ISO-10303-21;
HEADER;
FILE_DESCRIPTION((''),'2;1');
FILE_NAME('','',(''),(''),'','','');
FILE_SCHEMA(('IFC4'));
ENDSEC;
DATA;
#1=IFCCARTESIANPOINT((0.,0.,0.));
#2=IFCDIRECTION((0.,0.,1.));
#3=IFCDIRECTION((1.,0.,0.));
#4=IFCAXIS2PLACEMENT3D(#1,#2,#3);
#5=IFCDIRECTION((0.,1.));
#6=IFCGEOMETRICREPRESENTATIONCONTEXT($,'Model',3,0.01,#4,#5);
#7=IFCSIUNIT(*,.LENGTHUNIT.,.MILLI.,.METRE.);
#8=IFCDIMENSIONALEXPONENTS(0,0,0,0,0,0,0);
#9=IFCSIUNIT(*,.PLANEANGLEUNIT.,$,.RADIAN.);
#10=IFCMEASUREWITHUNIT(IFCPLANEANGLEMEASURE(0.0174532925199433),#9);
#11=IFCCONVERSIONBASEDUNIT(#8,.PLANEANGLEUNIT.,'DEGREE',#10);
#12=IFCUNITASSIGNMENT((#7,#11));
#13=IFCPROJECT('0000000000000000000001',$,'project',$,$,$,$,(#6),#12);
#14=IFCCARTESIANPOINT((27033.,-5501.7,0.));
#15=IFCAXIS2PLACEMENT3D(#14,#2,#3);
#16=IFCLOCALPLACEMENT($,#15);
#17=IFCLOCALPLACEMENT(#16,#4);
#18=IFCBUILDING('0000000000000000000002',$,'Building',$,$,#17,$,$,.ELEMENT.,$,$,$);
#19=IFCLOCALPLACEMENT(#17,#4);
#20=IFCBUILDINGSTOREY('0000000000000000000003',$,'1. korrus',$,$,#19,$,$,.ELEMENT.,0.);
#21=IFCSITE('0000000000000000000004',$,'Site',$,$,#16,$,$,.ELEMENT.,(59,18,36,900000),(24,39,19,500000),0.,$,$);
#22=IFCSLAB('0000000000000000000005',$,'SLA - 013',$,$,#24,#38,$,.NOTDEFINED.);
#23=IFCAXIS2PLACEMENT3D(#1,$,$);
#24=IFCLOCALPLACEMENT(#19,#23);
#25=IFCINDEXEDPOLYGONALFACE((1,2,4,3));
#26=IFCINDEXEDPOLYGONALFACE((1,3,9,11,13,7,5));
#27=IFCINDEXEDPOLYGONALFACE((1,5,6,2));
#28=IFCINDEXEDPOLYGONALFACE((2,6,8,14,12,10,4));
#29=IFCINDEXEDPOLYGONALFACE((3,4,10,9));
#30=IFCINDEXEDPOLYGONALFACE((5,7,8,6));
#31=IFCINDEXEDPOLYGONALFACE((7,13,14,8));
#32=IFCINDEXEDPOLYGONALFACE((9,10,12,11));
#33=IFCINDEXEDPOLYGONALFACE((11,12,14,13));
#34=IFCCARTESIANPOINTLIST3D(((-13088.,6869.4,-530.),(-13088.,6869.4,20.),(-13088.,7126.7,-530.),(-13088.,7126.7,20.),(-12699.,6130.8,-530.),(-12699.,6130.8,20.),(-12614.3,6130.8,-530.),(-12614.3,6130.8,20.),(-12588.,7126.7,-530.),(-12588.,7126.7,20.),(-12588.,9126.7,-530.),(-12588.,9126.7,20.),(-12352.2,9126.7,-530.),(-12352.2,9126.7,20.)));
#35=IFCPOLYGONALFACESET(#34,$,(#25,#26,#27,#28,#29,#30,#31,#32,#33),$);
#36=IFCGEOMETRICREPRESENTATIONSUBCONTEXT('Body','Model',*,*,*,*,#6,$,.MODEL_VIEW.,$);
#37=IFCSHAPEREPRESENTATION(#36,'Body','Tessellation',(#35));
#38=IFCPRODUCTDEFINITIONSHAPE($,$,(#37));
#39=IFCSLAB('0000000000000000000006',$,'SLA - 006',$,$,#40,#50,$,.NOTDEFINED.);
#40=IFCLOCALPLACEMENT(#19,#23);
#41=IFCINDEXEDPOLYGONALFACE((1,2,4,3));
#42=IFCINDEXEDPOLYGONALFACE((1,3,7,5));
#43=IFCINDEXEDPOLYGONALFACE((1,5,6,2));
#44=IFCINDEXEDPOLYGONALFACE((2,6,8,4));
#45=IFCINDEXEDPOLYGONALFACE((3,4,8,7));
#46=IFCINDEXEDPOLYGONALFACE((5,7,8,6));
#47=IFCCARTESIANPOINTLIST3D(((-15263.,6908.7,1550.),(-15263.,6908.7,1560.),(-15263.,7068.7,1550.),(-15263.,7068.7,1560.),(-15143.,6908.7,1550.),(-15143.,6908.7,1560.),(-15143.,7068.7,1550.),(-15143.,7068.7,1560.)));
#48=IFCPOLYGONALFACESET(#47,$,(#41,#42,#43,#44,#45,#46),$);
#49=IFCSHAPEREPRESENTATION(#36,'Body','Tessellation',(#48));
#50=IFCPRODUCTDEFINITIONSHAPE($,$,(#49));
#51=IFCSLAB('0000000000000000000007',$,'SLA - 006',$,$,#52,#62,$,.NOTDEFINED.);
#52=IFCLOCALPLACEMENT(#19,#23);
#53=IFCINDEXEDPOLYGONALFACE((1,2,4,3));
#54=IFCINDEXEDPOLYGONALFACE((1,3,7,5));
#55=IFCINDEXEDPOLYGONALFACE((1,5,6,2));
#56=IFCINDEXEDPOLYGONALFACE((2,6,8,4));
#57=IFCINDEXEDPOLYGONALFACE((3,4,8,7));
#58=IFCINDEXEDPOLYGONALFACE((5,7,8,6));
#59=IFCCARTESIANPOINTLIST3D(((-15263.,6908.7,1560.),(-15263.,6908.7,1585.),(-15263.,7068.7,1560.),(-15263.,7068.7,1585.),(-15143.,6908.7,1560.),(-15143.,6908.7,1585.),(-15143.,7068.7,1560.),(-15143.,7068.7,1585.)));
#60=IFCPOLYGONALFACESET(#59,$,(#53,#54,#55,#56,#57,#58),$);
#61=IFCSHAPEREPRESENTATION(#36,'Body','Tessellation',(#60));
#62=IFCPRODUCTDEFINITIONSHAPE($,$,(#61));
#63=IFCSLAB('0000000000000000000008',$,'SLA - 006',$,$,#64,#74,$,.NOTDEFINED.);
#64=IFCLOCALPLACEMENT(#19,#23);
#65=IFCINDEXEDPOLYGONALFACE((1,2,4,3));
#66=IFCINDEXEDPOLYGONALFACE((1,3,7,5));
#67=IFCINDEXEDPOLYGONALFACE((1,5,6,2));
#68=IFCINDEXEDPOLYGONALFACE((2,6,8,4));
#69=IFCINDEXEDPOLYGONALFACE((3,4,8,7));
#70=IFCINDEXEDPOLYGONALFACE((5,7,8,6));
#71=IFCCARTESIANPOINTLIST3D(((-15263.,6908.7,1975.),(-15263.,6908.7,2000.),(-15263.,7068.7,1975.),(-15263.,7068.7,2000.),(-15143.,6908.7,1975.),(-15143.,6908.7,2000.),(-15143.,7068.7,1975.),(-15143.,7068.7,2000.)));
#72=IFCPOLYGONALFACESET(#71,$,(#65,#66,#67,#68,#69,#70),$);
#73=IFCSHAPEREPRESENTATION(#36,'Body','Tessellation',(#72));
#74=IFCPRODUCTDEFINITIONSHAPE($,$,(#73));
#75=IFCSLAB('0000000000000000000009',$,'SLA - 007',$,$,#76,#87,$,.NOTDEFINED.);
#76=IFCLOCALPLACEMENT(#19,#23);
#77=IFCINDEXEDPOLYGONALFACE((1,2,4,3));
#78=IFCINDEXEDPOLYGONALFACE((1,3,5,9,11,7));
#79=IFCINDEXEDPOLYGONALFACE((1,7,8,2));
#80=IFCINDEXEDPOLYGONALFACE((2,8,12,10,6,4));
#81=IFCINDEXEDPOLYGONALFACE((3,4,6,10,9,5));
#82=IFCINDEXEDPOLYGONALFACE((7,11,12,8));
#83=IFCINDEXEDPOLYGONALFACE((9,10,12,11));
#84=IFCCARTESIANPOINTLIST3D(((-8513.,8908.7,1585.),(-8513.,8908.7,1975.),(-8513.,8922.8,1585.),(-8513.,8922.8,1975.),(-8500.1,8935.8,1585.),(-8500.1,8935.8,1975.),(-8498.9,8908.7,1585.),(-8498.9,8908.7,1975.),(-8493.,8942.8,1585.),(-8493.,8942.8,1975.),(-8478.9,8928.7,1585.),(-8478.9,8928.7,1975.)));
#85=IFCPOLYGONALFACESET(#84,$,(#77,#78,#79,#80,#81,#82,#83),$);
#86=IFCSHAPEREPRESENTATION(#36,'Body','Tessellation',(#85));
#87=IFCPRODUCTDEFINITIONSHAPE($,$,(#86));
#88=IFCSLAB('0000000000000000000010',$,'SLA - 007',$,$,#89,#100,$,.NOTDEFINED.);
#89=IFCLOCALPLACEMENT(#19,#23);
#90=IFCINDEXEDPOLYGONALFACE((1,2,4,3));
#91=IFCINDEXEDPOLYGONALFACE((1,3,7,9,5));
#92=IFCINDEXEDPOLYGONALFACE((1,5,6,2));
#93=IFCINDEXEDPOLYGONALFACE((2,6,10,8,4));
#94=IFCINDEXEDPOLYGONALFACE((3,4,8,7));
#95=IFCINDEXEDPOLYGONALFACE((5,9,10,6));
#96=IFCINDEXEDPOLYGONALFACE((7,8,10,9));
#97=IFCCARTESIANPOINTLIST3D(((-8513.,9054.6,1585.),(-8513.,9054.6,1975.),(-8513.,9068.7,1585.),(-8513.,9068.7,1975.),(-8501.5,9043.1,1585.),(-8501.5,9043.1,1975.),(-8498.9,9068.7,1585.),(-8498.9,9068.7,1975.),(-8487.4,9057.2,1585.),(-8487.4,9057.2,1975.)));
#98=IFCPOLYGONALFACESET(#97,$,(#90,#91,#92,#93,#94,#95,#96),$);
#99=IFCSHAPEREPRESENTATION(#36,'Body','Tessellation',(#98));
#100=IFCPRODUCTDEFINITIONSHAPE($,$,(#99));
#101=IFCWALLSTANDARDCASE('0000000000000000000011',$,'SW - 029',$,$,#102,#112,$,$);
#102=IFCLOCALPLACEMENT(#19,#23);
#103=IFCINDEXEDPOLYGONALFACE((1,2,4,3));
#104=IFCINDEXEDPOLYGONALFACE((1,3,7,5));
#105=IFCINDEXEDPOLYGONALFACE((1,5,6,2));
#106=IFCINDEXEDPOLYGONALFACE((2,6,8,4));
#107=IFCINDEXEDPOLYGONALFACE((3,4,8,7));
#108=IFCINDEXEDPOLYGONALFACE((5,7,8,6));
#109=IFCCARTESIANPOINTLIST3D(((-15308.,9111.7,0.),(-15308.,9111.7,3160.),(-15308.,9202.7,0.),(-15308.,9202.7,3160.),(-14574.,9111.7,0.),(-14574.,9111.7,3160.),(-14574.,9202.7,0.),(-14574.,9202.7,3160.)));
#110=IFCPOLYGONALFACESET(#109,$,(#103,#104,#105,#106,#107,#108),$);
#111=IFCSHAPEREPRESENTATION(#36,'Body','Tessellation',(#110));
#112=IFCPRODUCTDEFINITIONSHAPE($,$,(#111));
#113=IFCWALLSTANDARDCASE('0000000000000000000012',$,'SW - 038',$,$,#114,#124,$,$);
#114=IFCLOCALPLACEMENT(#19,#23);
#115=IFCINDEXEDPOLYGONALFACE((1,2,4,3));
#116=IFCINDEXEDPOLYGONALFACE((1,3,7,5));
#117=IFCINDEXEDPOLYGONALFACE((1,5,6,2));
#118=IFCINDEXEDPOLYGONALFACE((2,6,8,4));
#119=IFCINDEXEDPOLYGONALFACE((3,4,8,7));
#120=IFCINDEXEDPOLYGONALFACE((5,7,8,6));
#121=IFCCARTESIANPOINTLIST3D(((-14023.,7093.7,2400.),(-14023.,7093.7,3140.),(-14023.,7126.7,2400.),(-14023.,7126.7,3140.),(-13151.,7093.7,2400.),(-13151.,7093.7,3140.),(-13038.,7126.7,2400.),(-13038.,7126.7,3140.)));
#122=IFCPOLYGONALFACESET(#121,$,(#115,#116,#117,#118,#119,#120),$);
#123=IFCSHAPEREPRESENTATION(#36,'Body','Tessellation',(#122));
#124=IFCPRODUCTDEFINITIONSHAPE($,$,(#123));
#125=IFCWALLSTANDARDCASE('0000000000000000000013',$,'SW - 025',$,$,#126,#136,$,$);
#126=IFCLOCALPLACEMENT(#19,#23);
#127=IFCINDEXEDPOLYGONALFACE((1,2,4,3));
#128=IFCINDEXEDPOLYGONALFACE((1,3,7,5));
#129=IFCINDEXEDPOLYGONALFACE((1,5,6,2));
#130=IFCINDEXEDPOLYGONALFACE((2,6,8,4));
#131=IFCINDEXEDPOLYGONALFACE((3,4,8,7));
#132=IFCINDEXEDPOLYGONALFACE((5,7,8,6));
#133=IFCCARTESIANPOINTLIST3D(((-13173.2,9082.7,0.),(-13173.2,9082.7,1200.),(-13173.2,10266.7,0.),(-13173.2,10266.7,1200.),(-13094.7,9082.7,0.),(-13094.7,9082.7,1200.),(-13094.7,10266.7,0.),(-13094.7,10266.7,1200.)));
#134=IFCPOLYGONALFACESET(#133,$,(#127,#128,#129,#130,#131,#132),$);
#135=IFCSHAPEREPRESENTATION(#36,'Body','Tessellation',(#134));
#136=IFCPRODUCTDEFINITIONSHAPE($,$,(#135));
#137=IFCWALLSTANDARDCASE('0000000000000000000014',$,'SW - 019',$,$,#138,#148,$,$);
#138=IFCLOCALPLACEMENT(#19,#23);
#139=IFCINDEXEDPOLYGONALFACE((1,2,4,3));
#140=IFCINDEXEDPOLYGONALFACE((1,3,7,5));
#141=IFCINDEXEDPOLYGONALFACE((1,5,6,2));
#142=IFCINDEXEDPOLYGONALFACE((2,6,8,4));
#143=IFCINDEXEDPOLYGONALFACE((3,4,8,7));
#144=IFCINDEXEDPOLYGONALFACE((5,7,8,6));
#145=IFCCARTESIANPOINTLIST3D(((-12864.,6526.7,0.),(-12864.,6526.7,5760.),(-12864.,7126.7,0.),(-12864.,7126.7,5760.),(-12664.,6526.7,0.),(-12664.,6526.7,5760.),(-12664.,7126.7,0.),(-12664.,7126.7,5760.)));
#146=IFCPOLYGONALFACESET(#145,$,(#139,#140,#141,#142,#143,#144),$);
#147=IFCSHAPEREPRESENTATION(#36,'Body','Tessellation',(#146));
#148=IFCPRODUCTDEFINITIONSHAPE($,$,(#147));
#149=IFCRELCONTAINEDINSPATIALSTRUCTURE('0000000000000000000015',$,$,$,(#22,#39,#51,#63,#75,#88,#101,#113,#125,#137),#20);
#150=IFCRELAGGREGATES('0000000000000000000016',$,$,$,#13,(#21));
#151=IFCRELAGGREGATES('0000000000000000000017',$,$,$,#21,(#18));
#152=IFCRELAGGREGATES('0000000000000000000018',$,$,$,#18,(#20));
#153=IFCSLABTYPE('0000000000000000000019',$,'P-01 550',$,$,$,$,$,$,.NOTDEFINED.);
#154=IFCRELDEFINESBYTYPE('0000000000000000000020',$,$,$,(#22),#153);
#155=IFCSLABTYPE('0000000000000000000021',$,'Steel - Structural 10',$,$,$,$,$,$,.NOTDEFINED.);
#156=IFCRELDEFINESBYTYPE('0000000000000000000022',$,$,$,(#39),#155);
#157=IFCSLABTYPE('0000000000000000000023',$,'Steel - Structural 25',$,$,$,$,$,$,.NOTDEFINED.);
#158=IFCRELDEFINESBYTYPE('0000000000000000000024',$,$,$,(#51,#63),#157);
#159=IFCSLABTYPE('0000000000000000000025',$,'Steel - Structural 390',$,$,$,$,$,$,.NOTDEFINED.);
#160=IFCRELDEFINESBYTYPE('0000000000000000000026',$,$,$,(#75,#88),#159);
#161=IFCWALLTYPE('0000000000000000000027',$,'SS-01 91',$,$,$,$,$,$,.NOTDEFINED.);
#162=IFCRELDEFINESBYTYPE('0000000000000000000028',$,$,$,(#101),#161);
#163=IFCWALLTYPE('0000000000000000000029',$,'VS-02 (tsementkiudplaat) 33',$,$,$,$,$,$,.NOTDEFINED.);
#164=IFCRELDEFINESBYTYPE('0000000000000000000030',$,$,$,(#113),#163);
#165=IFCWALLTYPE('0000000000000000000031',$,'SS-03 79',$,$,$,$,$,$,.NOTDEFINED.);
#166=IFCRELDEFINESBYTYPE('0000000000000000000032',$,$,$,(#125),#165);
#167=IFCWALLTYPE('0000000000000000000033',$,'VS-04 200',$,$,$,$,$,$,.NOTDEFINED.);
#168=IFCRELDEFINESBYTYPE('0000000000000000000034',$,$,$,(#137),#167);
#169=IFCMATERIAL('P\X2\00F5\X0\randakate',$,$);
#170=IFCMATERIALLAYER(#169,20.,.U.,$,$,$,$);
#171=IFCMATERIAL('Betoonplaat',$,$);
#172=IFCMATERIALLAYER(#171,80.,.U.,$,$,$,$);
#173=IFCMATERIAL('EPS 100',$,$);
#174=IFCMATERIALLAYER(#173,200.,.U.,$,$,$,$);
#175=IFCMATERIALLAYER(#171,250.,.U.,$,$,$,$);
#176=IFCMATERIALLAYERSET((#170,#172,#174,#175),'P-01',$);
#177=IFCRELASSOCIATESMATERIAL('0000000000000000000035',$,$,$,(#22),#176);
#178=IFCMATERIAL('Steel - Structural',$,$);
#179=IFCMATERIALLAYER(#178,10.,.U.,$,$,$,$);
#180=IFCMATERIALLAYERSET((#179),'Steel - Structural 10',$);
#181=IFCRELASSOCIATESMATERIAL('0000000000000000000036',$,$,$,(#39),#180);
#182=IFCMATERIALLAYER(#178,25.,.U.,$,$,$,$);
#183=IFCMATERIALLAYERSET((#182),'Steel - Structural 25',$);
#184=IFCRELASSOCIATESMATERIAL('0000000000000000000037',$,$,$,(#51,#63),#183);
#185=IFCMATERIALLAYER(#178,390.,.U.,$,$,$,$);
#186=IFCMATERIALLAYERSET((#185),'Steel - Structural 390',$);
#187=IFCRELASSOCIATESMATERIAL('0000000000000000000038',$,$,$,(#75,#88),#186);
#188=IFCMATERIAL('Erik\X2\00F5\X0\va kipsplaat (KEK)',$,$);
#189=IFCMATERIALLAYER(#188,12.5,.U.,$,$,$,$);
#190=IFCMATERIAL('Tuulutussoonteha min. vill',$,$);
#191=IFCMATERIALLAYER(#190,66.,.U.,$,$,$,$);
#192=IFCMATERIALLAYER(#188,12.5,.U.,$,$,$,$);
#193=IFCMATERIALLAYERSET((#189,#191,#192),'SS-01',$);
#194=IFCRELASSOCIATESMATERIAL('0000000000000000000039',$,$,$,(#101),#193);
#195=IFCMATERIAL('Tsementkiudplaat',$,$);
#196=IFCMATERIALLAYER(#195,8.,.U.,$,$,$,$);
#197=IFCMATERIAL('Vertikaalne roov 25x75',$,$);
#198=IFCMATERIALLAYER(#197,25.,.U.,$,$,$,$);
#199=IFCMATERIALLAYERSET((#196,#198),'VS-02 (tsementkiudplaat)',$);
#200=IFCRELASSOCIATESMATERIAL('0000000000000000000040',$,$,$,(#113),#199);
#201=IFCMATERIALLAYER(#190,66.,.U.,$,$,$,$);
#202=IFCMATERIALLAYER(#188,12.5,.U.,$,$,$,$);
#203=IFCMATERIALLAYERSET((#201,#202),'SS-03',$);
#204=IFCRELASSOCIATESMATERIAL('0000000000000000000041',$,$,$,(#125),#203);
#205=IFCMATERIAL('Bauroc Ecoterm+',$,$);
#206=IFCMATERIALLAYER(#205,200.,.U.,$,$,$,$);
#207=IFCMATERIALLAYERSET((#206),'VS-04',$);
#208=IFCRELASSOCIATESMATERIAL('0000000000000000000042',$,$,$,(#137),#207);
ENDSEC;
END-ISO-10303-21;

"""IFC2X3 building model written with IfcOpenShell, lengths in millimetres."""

from ifc_helpers import new_model, entity, si_unit, converted_unit, direction, frame, origin_with_axes, origin_2d_with_axis, place, context, subcontext, project, spatial, polyline, rectangle, outline, extrude, material, layer, layer_set, layer_usage, type_object, element, save


model = new_model("IFC2X3")

# Units and contexts
model_context = context("Model", 3, precision=0.01, world=origin_with_axes(), true_north=direction((0.0, 1.0)))
body_context = subcontext(model_context, "Body", "Model", "MODEL_VIEW")
ifc_project = project(units=[si_unit("LENGTHUNIT", "METRE", prefix="MILLI"), converted_unit("PLANEANGLEUNIT", "DEGREE", entity("IfcPlaneAngleMeasure", 0.0174532925199433), si_unit("PLANEANGLEUNIT", "RADIAN"), dimensions=[0, 0, 0, 0, 0, 0, 0])], contexts=[model_context])

# Site, building, storey
site_placement = place(None, frame((27033.0, -5501.7, 0.0), z_axis=(0.0, 0.0, 1.0), x_axis=(1.0, 0.0, 0.0)))
site = spatial("IfcSite", under=ifc_project, at=site_placement, Name="Site", CompositionType="ELEMENT", RefLatitude=(59, 18, 36, 900000), RefLongitude=(24, 39, 19, 500000), RefElevation=0.0)
building_placement = place(site_placement, origin_with_axes())
building = spatial("IfcBuilding", under=site, at=building_placement, Name="Building", CompositionType="ELEMENT")
storey_placement = place(building_placement, origin_with_axes())
storey = spatial("IfcBuildingStorey", under=building, at=storey_placement, Name="1. korrus", CompositionType="ELEMENT", Elevation=0.0)

# Slabs
ifc_material_1 = material(Name="Põrandakate")
ifc_layer_1 = layer(ifc_material_1, 20.0, ventilated="UNKNOWN")
ifc_material_2 = material(Name="Betoonplaat")
ifc_layer_2 = layer(ifc_material_2, 80.0, ventilated="UNKNOWN")
ifc_material_3 = material(Name="EPS 100")
ifc_layer_3 = layer(ifc_material_3, 200.0, ventilated="UNKNOWN")
ifc_layer_4 = layer(ifc_material_2, 250.0, ventilated="UNKNOWN")
ifc_layer_set_1 = layer_set([ifc_layer_1, ifc_layer_2, ifc_layer_3, ifc_layer_4], Name="P-01")
ifc_layer_usage_1 = layer_usage(ifc_layer_set_1, "AXIS3", "NEGATIVE", 550.0)
slab_type_1 = type_object("IfcSlabType", Name="P-01 550", PredefinedType="NOTDEFINED")
slab_1_placement = place(storey_placement, frame((-12588.0, 7126.7, 0.0), z_axis=(0.0, 0.0, 1.0), x_axis=(1.0, 0.0, 0.0)))
element("IfcSlab", 1, at=slab_1_placement, inside=storey, type_object=slab_type_1, material=ifc_layer_usage_1, Name="SLA - 013", PredefinedType="NOTDEFINED", context=body_context, shape_type="SweptSolid", body=[
    extrude(outline(polyline([(0.0, 0.0), (-500.0, 0.0), (-500.0, -257.3), (-111.0, -995.9), (-26.3, -995.9), (235.8, 2000.0), (0.0, 2000.0), (0.0, 0.0)])), frame((0.0, 0.0, -530.0), z_axis=(0.0, 0.0, 1.0), x_axis=(1.0, 0.0, 0.0)), (0.0, 0.0, 1.0), 550.0),
])
ifc_material_4 = material(Name="Steel - Structural")
ifc_layer_5 = layer(ifc_material_4, 10.0, ventilated="UNKNOWN")
ifc_layer_set_2 = layer_set([ifc_layer_5], Name="Steel - Structural 10")
ifc_layer_usage_2 = layer_usage(ifc_layer_set_2, "AXIS3", "NEGATIVE", 10.0)
slab_type_2 = type_object("IfcSlabType", Name="Steel - Structural 10", PredefinedType="NOTDEFINED")
slab_2_placement = place(storey_placement, frame((-15143.0, 7068.7, 1550.0), z_axis=(0.0, 0.0, 1.0), x_axis=(1.0, 0.0, 0.0)))
element("IfcSlab", 2, at=slab_2_placement, inside=storey, type_object=slab_type_2, material=ifc_layer_usage_2, Name="SLA - 006", PredefinedType="NOTDEFINED", context=body_context, shape_type="SweptSolid", body=[
    extrude(outline(polyline([(0.0, 0.0), (-120.0, 0.0), (-120.0, -160.0), (0.0, -160.0), (0.0, 0.0)])), origin_with_axes(), (0.0, 0.0, 1.0), 10.0),
])
ifc_layer_6 = layer(ifc_material_4, 25.0, ventilated="UNKNOWN")
ifc_layer_set_3 = layer_set([ifc_layer_6], Name="Steel - Structural 25")
ifc_layer_usage_3 = layer_usage(ifc_layer_set_3, "AXIS3", "NEGATIVE", 25.0)
slab_type_3 = type_object("IfcSlabType", Name="Steel - Structural 25", PredefinedType="NOTDEFINED")
slab_3_placement = place(storey_placement, frame((-15143.0, 7068.7, 1560.0), z_axis=(0.0, 0.0, 1.0), x_axis=(1.0, 0.0, 0.0)))
element("IfcSlab", 3, at=slab_3_placement, inside=storey, type_object=slab_type_3, material=ifc_layer_usage_3, Name="SLA - 006", PredefinedType="NOTDEFINED", context=body_context, shape_type="SweptSolid", body=[
    extrude(outline(polyline([(0.0, 0.0), (-120.0, 0.0), (-120.0, -160.0), (0.0, -160.0), (0.0, 0.0)])), origin_with_axes(), (0.0, 0.0, 1.0), 25.0),
])
ifc_layer_usage_4 = layer_usage(ifc_layer_set_3, "AXIS3", "NEGATIVE", 25.0)
slab_4_placement = place(storey_placement, frame((-15143.0, 7068.7, 2000.0), z_axis=(0.0, 0.0, 1.0), x_axis=(1.0, 0.0, 0.0)))
element("IfcSlab", 4, at=slab_4_placement, inside=storey, type_object=slab_type_3, material=ifc_layer_usage_4, Name="SLA - 006", PredefinedType="NOTDEFINED", context=body_context, shape_type="SweptSolid", body=[
    extrude(outline(polyline([(0.0, 0.0), (-120.0, 0.0), (-120.0, -160.0), (0.0, -160.0), (0.0, 0.0)])), frame((0.0, 0.0, -25.0), z_axis=(0.0, 0.0, 1.0), x_axis=(1.0, 0.0, 0.0)), (0.0, 0.0, 1.0), 25.0),
])
ifc_layer_7 = layer(ifc_material_4, 390.0, ventilated="UNKNOWN")
ifc_layer_set_4 = layer_set([ifc_layer_7], Name="Steel - Structural 390")
ifc_layer_usage_5 = layer_usage(ifc_layer_set_4, "AXIS3", "NEGATIVE", 390.0)
slab_type_4 = type_object("IfcSlabType", Name="Steel - Structural 390", PredefinedType="NOTDEFINED")
slab_5_placement = place(storey_placement, frame((-8500.1, 8935.8, 1585.0), z_axis=(0.0, 0.0, 1.0), x_axis=(1.0, 0.0, 0.0)))
element("IfcSlab", 5, at=slab_5_placement, inside=storey, type_object=slab_type_4, material=ifc_layer_usage_5, Name="SLA - 007", PredefinedType="NOTDEFINED", context=body_context, shape_type="SweptSolid", body=[
    extrude(outline(polyline([(0.0, 0.0), (-12.9, -12.9), (-12.9, -27.1), (1.2, -27.1), (21.2, -7.1), (7.1, 7.1), (0.0, 0.0)])), origin_with_axes(), (0.0, 0.0, 1.0), 390.0),
])
ifc_layer_usage_6 = layer_usage(ifc_layer_set_4, "AXIS3", "NEGATIVE", 390.0)
slab_6_placement = place(storey_placement, frame((-8501.5, 9043.1, 1585.0), z_axis=(0.0, 0.0, 1.0), x_axis=(1.0, 0.0, 0.0)))
element("IfcSlab", 6, at=slab_6_placement, inside=storey, type_object=slab_type_4, material=ifc_layer_usage_6, Name="SLA - 007", PredefinedType="NOTDEFINED", context=body_context, shape_type="SweptSolid", body=[
    extrude(outline(polyline([(0.0, 0.0), (14.1, 14.1), (2.7, 25.6), (-11.5, 25.6), (-11.5, 11.5), (0.0, 0.0)])), origin_with_axes(), (0.0, 0.0, 1.0), 390.0),
])

# Shared definitions
ifc_material_5 = material(Name="Bauroc Ecoterm+")

# Shared definitions
ifc_material_6 = material(Name="Erikõva kipsplaat (KEK)")
ifc_layer_8 = layer(ifc_material_6, 12.5, ventilated="UNKNOWN")
ifc_material_7 = material(Name="Tuulutussoonteha min. vill")
ifc_layer_9 = layer(ifc_material_7, 66.0, ventilated="UNKNOWN")
ifc_layer_10 = layer(ifc_material_6, 12.5, ventilated="UNKNOWN")
ifc_layer_set_5 = layer_set([ifc_layer_8, ifc_layer_9, ifc_layer_10], Name="SS-01")
wall_type_1 = type_object("IfcWallType", Name="SS-01 91", PredefinedType="NOTDEFINED")

# Wall
ifc_layer_usage_7 = layer_usage(ifc_layer_set_5, "AXIS2", "POSITIVE", -91.0)
wall_1_placement = place(storey_placement, frame((-14574.0, 9111.7, 0.0), z_axis=(0.0, 0.0, 1.0), x_axis=(-1.0, 0.0, 0.0)))
element("IfcWallStandardCase", 7, at=wall_1_placement, inside=storey, type_object=wall_type_1, material=ifc_layer_usage_7, Name="SW - 029", context=body_context, shape_type="SweptSolid", body=[
    extrude(outline(polyline([(0.0, -91.0), (734.0, -91.0), (734.0, 0.0), (0.0, 0.0), (0.0, -91.0)])), origin_with_axes(), (0.0, 0.0, 1.0), 3160.0),
])

# Wall, opening
ifc_material_8 = material(Name="Tsementkiudplaat")
ifc_layer_11 = layer(ifc_material_8, 8.0, ventilated="UNKNOWN")
ifc_material_9 = material(Name="Vertikaalne roov 25x75")
ifc_layer_12 = layer(ifc_material_9, 25.0, ventilated="UNKNOWN")
ifc_layer_set_6 = layer_set([ifc_layer_11, ifc_layer_12], Name="VS-02 (tsementkiudplaat)")
ifc_layer_usage_8 = layer_usage(ifc_layer_set_6, "AXIS2", "POSITIVE", -33.0)
wall_type_2 = type_object("IfcWallType", Name="VS-02 (tsementkiudplaat) 33", PredefinedType="NOTDEFINED")
wall_2_placement = place(storey_placement, frame((-14023.0, 7126.7, 2400.0), z_axis=(0.0, 0.0, 1.0), x_axis=(1.0, 0.0, 0.0)))
wall_2 = element("IfcWallStandardCase", 8, at=wall_2_placement, inside=storey, type_object=wall_type_2, material=ifc_layer_usage_8, Name="SW - 038", context=body_context, shape_type="SweptSolid", body=[
    extrude(outline(polyline([(0.0, -33.0), (872.0, -33.0), (985.0, 0.0), (0.0, 0.0), (0.0, -33.0)])), origin_with_axes(), (0.0, 0.0, 1.0), 740.0),
])
opening_1_placement = place(wall_2_placement, frame((431.0, 0.0, -2400.0), z_axis=(0.0, 0.0, 1.0), x_axis=(1.0, 0.0, 0.0)))
element("IfcOpeningElement", 9, at=opening_1_placement, cuts=wall_2, context=body_context, shape_type="SweptSolid", body=[
    extrude(rectangle(XDim=882.0, YDim=2400.0, at=origin_2d_with_axis()), frame((0.0, 33.0, 1200.0), z_axis=(0.0, 1.0, 0.0), x_axis=(-1.0, 0.0, 0.0)), (0.0, 0.0, -1.0), 99.0),
])

# Walls
ifc_layer_13 = layer(ifc_material_7, 66.0, ventilated="UNKNOWN")
ifc_layer_14 = layer(ifc_material_6, 12.5, ventilated="UNKNOWN")
ifc_layer_set_7 = layer_set([ifc_layer_13, ifc_layer_14], Name="SS-03")
ifc_layer_usage_9 = layer_usage(ifc_layer_set_7, "AXIS2", "POSITIVE", -78.5)
wall_type_3 = type_object("IfcWallType", Name="SS-03 79", PredefinedType="NOTDEFINED")
wall_3_placement = place(storey_placement, frame((-13173.2, 9082.7, 0.0), z_axis=(0.0, 0.0, 1.0), x_axis=(0.0, 1.0, 0.0)))
element("IfcWallStandardCase", 10, at=wall_3_placement, inside=storey, type_object=wall_type_3, material=ifc_layer_usage_9, Name="SW - 025", context=body_context, shape_type="SweptSolid", body=[
    extrude(outline(polyline([(0.0, -78.5), (1184.0, -78.5), (1184.0, 0.0), (0.0, 0.0), (0.0, -78.5)])), origin_with_axes(), (0.0, 0.0, 1.0), 1200.0),
])
ifc_layer_15 = layer(ifc_material_5, 200.0, ventilated="UNKNOWN")
ifc_layer_set_8 = layer_set([ifc_layer_15], Name="VS-04")
ifc_layer_usage_10 = layer_usage(ifc_layer_set_8, "AXIS2", "POSITIVE", 0.0)
wall_type_4 = type_object("IfcWallType", Name="VS-04 200", PredefinedType="NOTDEFINED")
wall_4_placement = place(storey_placement, frame((-12864.0, 7126.7, 0.0), z_axis=(0.0, 0.0, 1.0), x_axis=(0.0, -1.0, 0.0)))
element("IfcWallStandardCase", 11, at=wall_4_placement, inside=storey, type_object=wall_type_4, material=ifc_layer_usage_10, Name="SW - 019", context=body_context, shape_type="SweptSolid", body=[
    extrude(outline(polyline([(0.0, 0.0), (600.0, 0.0), (600.0, 200.0), (0.0, 200.0), (0.0, 0.0)])), origin_with_axes(), (0.0, 0.0, 1.0), 5760.0),
])

save(model, "model.ifc")
